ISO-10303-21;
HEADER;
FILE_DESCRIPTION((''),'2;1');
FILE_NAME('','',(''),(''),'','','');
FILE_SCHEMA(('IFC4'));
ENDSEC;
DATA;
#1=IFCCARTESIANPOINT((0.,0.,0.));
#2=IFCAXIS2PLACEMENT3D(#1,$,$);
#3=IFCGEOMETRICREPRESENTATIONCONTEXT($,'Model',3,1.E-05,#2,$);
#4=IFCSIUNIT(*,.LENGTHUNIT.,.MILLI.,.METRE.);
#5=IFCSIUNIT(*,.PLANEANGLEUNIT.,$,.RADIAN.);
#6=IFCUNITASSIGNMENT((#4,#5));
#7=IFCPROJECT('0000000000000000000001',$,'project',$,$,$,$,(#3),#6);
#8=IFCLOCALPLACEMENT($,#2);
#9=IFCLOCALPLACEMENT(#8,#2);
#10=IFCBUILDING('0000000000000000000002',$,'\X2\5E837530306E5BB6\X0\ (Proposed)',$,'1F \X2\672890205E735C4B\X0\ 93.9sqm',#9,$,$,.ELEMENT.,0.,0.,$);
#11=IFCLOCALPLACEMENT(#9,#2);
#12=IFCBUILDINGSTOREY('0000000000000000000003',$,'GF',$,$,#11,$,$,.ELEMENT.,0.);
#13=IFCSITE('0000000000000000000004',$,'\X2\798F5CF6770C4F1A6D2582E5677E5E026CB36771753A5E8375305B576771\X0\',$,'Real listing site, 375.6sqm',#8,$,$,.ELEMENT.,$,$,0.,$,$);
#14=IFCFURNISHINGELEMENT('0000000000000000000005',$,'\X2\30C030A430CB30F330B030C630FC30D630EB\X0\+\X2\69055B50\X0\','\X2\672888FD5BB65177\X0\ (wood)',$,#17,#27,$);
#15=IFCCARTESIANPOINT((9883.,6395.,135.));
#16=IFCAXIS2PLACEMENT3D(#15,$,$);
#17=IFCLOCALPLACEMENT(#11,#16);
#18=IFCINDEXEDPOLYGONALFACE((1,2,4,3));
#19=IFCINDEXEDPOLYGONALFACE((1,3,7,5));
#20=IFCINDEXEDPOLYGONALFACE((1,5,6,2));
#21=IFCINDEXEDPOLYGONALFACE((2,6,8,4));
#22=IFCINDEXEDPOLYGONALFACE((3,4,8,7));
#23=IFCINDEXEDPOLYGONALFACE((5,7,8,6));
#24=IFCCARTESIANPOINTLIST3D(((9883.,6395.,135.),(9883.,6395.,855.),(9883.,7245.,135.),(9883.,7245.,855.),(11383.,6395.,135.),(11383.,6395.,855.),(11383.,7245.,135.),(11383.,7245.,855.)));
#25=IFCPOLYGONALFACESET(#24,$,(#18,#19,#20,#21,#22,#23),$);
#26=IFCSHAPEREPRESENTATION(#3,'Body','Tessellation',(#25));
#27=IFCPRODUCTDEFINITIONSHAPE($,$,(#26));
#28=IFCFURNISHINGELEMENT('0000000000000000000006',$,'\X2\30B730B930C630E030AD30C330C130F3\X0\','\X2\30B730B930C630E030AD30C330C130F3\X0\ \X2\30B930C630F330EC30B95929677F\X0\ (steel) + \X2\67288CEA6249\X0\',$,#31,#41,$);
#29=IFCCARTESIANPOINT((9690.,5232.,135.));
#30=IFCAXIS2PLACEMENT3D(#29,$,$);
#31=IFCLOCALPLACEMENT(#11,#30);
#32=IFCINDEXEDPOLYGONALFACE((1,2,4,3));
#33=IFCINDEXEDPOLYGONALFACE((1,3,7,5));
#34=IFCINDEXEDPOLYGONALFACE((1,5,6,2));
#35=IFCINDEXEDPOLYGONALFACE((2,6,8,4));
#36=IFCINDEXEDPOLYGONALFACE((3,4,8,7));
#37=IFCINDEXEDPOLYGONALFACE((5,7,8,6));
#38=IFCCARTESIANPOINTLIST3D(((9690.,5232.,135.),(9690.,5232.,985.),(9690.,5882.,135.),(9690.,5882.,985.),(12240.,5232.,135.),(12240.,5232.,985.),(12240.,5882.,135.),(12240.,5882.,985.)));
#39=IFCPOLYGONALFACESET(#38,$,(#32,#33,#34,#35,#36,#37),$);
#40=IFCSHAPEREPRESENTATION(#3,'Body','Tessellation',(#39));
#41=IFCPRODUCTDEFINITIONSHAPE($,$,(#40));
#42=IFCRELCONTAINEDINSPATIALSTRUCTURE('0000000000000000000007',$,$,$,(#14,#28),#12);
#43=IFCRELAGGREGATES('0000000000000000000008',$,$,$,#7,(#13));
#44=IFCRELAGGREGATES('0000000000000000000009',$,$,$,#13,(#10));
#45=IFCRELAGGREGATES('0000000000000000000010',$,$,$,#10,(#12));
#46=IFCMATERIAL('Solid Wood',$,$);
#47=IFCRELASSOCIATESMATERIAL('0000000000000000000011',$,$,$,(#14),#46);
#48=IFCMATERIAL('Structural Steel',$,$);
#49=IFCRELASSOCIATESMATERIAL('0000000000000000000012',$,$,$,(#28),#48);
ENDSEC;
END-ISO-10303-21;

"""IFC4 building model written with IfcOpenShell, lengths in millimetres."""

from ifc_helpers import new_model, si_unit, frame, frame_2d, origin, place, context, project, spatial, rectangle, extrude, material, element, save


model = new_model("IFC4")

# Units and contexts
model_context = context("Model", 3, precision=1e-05, world=origin())
ifc_project = project(units=[si_unit("LENGTHUNIT", "METRE", prefix="MILLI"), si_unit("PLANEANGLEUNIT", "RADIAN")], contexts=[model_context])

# Site, building, storey
site_placement = place(None, origin())
site = spatial("IfcSite", under=ifc_project, at=site_placement, Name="福島県会津若松市河東町広田字東", ObjectType="Real listing site, 375.6sqm", CompositionType="ELEMENT", RefElevation=0.0)
building_placement = place(site_placement, origin())
building = spatial("IfcBuilding", under=site, at=building_placement, Name="広田の家 (Proposed)", ObjectType="1F 木造平屋 93.9sqm", CompositionType="ELEMENT", ElevationOfRefHeight=0.0, ElevationOfTerrain=0.0)
storey_placement = place(building_placement, origin())
storey = spatial("IfcBuildingStorey", under=building, at=storey_placement, Name="GF", CompositionType="ELEMENT", Elevation=0.0)

# Shared definitions
ifc_material_1 = material(Name="Solid Wood")

# Shared definitions
ifc_material_2 = material(Name="Structural Steel")

# Furnishing elements
furnishing_1_placement = place(storey_placement, frame((9883.0, 6395.0, 135.0)))
element("IfcFurnishingElement", 1, at=furnishing_1_placement, inside=storey, material=ifc_material_1, Name="ダイニングテーブル+椅子", Description="木製家具 (wood)", context=model_context, shape_type="SweptSolid", body=[
    extrude(rectangle(XDim=1500.0, YDim=850.0, at=frame_2d((750.0, 425.0))), frame((9883.0, 6395.0, 135.0)), (0.0, 0.0, 1.0), 720.0),
])
furnishing_2_placement = place(storey_placement, frame((9690.0, 5232.0, 135.0)))
element("IfcFurnishingElement", 2, at=furnishing_2_placement, inside=storey, material=ifc_material_2, Name="システムキッチン", Description="システムキッチン ステンレス天板 (steel) + 木質扉", context=model_context, shape_type="SweptSolid", body=[
    extrude(rectangle(XDim=2550.0, YDim=650.0, at=frame_2d((1275.0, 325.0))), frame((9690.0, 5232.0, 135.0)), (0.0, 0.0, 1.0), 850.0),
])

save(model, "model.ifc")
